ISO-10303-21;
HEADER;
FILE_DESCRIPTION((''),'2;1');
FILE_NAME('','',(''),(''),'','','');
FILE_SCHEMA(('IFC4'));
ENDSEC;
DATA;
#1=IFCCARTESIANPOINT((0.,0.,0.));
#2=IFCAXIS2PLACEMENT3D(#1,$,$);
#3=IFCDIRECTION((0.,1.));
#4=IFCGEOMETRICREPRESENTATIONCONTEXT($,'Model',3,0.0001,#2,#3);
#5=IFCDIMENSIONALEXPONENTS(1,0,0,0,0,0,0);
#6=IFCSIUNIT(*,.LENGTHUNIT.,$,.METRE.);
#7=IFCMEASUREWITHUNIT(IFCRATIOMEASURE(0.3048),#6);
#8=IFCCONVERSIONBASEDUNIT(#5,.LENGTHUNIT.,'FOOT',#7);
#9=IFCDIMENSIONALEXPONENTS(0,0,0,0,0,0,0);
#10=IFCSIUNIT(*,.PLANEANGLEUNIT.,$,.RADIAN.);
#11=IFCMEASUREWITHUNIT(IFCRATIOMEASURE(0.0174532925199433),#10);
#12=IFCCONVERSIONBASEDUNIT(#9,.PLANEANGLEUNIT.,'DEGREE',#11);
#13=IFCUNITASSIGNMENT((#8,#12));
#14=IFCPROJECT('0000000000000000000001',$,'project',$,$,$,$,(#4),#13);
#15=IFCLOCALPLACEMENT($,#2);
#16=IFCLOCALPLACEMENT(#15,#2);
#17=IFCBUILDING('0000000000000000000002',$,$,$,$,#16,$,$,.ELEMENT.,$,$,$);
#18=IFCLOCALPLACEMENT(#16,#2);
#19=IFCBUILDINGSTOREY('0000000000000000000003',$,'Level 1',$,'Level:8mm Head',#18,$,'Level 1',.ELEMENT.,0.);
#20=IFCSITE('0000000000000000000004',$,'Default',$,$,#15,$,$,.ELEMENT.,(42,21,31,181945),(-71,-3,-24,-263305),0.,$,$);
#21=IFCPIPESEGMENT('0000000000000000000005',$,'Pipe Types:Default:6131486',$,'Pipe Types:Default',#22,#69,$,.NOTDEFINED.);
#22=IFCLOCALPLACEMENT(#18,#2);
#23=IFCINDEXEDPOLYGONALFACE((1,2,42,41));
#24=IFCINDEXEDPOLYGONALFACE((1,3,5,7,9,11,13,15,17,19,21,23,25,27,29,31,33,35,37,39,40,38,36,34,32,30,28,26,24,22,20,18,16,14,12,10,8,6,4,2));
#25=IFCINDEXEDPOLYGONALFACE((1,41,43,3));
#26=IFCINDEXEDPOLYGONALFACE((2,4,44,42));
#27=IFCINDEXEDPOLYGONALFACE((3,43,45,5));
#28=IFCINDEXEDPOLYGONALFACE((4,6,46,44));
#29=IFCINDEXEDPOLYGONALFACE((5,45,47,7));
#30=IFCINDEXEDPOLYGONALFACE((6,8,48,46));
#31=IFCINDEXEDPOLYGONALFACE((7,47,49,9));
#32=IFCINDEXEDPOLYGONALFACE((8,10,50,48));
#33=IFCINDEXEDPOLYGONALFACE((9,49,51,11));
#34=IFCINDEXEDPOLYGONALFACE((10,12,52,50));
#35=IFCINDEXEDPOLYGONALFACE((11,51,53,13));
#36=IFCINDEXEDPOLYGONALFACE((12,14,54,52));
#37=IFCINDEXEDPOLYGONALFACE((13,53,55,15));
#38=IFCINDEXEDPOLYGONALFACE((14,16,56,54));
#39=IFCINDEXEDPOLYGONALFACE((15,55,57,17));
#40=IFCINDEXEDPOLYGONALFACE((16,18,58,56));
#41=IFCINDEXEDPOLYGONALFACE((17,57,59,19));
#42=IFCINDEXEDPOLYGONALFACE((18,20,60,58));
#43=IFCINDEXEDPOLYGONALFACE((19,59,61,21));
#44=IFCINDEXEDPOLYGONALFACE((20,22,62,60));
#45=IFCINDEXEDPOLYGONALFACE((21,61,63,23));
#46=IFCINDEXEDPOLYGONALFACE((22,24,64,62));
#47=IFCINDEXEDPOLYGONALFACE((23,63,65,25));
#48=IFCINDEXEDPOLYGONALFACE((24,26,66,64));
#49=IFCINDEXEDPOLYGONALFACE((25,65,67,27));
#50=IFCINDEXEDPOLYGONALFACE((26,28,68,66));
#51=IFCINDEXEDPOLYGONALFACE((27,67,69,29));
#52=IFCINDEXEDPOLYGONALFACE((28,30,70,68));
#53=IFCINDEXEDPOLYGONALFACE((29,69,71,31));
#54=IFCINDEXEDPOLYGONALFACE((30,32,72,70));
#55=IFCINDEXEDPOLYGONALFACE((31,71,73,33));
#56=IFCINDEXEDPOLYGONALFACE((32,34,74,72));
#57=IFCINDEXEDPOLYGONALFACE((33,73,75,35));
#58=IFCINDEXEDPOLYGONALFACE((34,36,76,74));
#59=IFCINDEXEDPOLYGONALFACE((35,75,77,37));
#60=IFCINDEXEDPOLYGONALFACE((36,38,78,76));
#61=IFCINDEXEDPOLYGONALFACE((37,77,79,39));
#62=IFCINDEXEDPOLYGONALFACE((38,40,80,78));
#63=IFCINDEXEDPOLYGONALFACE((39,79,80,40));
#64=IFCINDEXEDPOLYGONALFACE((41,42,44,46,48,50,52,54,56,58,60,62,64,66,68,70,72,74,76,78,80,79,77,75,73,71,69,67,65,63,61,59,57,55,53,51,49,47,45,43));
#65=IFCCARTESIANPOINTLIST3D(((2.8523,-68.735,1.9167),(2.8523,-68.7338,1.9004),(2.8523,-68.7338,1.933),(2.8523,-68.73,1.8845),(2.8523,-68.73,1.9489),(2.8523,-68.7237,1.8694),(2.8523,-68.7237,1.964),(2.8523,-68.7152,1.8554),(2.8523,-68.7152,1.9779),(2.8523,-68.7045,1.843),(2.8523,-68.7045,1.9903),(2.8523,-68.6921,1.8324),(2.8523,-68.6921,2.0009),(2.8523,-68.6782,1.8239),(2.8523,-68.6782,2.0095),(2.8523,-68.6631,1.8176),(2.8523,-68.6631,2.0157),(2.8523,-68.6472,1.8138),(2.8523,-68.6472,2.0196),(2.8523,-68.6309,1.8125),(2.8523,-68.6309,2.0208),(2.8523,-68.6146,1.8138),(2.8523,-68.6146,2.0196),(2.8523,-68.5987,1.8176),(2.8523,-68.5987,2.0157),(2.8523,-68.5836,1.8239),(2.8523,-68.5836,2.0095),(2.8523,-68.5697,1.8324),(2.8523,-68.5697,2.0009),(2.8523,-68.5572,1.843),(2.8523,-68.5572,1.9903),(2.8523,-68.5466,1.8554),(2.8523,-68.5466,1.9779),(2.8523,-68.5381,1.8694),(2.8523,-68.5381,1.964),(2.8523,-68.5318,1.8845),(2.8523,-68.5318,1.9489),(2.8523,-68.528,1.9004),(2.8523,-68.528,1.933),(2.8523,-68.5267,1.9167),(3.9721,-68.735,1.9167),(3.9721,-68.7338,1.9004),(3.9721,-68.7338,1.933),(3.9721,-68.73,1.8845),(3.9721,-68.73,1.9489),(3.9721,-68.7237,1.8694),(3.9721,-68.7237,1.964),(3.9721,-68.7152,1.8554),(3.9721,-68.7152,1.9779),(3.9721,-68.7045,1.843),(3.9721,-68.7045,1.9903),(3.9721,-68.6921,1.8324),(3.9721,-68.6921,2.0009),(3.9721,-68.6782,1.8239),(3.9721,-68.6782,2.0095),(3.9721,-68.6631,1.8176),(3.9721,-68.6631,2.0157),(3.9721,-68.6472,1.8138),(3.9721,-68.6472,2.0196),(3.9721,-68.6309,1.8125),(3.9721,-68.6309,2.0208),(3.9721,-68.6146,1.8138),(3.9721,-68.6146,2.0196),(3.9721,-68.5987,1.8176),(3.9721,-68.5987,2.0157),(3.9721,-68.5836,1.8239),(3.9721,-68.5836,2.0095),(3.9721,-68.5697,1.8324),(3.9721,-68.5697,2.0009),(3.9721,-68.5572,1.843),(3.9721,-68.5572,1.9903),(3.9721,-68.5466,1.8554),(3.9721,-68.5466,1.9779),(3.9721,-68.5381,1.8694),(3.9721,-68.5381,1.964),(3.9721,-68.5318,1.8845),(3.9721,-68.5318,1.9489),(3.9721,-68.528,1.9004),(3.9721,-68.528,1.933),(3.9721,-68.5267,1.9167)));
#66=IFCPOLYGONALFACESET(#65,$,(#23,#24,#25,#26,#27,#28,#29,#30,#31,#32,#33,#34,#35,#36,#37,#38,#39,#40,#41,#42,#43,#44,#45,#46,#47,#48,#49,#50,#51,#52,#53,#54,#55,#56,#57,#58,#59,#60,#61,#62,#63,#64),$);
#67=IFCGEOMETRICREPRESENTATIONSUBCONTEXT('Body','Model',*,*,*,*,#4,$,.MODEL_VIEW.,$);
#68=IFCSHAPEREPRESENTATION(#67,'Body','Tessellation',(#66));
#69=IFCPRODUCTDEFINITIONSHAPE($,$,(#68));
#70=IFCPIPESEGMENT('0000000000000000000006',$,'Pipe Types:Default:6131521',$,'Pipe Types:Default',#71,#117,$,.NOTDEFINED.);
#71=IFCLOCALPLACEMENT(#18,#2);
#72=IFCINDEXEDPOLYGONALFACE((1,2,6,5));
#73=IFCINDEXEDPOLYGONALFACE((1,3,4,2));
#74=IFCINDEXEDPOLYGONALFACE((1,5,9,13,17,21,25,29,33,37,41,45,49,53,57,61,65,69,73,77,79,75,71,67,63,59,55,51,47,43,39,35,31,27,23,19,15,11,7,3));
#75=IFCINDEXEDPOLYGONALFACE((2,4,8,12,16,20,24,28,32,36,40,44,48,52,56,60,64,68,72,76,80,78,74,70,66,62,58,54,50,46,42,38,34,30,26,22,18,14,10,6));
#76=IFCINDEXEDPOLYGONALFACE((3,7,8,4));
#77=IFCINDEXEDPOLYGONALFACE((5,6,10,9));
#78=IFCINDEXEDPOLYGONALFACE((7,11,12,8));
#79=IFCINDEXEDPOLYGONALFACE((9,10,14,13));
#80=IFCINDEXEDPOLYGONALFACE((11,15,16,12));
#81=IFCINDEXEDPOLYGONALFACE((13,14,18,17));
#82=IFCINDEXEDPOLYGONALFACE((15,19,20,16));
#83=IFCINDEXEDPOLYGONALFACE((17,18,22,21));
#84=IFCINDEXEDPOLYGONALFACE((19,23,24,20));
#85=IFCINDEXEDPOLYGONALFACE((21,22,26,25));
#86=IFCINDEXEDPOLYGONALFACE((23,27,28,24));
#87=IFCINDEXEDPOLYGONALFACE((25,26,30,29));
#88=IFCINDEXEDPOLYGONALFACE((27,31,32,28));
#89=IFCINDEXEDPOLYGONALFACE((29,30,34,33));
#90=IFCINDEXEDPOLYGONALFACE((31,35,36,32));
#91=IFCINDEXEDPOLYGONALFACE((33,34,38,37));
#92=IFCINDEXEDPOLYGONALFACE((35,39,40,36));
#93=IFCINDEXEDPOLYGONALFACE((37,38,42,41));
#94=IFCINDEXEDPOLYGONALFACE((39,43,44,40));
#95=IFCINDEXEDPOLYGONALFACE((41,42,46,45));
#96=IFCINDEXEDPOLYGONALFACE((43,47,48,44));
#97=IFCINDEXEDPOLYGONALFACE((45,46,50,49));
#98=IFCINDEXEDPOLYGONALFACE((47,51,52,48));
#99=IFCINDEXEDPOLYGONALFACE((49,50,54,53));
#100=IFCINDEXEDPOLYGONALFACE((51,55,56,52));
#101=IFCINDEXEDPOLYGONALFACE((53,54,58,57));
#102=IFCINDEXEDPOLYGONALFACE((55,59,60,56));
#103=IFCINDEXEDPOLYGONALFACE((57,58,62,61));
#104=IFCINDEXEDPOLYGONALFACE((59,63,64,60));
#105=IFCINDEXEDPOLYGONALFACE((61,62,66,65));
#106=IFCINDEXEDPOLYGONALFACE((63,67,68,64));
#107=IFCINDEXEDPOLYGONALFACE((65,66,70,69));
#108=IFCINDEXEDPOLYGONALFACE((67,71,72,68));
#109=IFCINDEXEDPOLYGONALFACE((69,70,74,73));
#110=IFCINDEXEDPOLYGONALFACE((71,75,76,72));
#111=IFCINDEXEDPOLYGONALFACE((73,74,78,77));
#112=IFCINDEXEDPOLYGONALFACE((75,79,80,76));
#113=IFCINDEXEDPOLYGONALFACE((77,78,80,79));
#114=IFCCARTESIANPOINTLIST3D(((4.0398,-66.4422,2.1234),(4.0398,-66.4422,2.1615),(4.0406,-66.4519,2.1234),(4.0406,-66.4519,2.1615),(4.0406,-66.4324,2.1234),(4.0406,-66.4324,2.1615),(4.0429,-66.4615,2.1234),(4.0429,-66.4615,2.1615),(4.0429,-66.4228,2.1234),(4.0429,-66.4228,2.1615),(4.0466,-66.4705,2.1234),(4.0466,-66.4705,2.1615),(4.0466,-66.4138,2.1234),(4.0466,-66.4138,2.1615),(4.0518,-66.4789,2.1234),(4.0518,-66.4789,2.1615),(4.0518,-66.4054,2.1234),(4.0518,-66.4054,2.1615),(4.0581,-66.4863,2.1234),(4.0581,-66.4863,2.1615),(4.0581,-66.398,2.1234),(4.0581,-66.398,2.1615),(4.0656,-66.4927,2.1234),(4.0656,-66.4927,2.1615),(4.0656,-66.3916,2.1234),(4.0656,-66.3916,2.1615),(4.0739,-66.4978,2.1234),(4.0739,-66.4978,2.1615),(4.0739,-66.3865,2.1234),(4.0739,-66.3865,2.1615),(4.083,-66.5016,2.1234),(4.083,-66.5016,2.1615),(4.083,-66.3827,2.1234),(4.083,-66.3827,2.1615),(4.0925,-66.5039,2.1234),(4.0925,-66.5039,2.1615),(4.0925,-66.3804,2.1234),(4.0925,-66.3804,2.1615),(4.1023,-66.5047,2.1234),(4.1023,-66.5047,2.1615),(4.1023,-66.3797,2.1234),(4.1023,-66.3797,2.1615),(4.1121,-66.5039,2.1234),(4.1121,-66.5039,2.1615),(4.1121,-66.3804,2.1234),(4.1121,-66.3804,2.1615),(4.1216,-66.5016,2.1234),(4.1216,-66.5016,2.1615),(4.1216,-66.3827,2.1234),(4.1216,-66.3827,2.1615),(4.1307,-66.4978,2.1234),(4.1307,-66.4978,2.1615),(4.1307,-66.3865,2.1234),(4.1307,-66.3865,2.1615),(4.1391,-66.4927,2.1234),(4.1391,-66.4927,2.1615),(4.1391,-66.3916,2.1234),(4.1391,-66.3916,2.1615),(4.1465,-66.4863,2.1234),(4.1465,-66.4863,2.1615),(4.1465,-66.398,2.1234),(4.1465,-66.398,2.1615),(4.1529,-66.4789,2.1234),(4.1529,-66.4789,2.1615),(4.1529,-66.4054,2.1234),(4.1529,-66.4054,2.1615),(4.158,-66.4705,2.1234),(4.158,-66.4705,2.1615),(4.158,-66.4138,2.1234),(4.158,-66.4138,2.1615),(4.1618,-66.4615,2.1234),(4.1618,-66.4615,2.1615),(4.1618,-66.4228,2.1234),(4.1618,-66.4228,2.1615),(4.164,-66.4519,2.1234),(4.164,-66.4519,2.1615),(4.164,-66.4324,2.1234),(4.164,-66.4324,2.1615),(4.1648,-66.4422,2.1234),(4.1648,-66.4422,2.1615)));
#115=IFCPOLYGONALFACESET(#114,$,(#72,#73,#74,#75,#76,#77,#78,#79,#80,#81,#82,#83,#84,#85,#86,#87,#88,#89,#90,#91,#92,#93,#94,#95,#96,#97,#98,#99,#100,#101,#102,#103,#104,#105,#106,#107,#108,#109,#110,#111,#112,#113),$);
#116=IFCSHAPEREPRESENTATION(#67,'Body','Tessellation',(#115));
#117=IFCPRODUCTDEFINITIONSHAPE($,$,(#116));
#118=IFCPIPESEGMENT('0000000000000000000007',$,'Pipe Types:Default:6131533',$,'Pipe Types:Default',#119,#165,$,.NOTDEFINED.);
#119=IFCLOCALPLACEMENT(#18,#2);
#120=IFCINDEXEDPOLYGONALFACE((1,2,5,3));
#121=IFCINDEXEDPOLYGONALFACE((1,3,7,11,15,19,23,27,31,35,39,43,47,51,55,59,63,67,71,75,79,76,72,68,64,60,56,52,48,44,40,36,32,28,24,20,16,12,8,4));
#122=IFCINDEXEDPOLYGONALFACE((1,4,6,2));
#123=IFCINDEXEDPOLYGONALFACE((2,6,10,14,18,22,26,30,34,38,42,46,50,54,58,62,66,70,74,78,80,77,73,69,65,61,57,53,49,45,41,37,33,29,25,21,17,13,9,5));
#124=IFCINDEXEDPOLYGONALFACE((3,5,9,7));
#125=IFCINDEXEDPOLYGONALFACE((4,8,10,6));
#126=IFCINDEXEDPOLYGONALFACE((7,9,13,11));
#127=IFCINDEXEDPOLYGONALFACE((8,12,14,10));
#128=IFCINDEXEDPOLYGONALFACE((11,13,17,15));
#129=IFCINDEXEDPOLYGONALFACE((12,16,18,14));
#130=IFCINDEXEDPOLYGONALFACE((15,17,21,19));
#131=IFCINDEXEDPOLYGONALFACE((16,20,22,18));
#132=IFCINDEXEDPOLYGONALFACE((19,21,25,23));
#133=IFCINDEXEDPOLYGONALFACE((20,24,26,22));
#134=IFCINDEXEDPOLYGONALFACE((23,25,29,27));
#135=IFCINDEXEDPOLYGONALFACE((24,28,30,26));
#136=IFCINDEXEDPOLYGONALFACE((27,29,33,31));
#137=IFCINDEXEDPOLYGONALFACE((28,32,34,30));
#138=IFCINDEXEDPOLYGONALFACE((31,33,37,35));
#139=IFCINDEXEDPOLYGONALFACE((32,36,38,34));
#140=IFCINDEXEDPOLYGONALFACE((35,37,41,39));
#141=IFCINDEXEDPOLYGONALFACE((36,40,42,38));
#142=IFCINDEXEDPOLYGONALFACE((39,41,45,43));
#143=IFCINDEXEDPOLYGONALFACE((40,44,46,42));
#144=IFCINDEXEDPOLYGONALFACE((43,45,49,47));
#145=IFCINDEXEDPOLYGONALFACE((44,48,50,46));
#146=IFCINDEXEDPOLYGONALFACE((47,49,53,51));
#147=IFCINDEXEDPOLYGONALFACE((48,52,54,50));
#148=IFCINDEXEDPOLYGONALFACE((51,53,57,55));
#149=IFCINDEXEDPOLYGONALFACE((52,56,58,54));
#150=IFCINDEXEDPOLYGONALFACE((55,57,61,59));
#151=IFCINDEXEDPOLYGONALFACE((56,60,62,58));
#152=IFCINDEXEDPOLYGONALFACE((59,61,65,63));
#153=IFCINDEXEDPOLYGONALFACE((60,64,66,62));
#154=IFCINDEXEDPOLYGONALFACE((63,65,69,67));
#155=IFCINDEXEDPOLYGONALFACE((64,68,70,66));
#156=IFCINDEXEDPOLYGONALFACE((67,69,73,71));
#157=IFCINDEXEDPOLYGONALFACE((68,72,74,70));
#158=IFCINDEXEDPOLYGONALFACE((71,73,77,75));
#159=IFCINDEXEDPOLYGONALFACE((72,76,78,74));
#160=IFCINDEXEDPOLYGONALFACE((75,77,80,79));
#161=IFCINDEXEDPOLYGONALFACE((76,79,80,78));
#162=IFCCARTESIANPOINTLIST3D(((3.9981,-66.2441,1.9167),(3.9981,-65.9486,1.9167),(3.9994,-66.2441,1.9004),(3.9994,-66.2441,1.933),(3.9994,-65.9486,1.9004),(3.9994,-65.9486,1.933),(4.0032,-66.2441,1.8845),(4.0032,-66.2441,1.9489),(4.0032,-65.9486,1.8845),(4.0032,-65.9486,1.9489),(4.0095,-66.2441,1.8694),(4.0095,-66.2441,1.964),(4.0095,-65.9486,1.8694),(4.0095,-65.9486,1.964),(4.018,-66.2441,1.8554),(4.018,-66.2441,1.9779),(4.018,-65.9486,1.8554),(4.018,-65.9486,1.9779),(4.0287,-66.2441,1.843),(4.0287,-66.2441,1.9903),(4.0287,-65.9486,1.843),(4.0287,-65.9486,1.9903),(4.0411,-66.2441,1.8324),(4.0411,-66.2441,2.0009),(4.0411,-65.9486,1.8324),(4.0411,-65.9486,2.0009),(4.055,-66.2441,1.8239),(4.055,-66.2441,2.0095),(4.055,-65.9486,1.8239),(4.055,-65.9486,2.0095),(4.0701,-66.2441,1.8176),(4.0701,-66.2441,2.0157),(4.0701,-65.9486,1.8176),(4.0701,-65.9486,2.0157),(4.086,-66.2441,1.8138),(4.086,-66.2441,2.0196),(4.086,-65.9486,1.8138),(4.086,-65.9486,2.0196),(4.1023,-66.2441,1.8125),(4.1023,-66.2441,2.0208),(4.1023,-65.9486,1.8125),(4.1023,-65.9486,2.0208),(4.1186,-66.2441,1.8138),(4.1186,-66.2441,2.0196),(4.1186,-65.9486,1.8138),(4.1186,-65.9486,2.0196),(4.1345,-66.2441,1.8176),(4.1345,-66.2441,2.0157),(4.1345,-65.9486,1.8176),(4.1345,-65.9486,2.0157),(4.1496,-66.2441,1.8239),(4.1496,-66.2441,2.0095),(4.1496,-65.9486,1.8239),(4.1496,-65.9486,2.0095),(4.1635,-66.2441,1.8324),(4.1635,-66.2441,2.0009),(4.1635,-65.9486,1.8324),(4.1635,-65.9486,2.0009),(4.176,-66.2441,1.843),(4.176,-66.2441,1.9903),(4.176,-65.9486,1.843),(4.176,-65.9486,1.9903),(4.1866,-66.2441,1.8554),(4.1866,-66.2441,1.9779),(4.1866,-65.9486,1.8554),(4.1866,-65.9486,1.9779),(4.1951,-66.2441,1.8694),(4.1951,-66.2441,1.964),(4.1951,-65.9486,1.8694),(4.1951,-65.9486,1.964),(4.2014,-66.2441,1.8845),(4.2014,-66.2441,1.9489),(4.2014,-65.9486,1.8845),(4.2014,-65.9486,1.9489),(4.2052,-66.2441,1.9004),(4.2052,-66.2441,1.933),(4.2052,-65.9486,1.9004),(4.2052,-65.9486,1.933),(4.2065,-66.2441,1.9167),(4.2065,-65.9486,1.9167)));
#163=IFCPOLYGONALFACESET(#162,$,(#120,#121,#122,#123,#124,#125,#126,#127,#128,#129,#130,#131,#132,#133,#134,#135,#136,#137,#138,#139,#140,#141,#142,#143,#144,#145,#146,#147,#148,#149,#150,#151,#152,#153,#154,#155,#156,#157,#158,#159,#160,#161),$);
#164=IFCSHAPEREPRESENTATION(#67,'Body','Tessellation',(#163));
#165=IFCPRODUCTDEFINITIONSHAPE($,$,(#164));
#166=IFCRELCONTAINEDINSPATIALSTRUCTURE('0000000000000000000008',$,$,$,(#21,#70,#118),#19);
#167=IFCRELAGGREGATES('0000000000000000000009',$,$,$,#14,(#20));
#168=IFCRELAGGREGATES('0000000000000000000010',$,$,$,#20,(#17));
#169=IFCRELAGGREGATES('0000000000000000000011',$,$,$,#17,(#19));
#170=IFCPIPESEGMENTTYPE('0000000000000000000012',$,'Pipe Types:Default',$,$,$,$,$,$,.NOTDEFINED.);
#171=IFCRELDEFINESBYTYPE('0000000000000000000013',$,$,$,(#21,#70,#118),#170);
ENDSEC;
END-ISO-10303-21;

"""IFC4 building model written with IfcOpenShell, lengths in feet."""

from ifc_helpers import new_model, entity, si_unit, converted_unit, direction, frame, origin, place, context, subcontext, project, spatial, indexed_curve, outline, extrude, type_object, element, save


model = new_model("IFC4")

# Units and contexts
model_context = context("Model", 3, precision=0.0001, world=origin(), true_north=direction((0.0, 1.0)))
body_context = subcontext(model_context, "Body", "Model", "MODEL_VIEW")
ifc_project = project(units=[converted_unit("LENGTHUNIT", "FOOT", entity("IfcRatioMeasure", 0.3048), si_unit("LENGTHUNIT", "METRE"), dimensions=[1, 0, 0, 0, 0, 0, 0]), converted_unit("PLANEANGLEUNIT", "DEGREE", entity("IfcRatioMeasure", 0.0174532925199433), si_unit("PLANEANGLEUNIT", "RADIAN"), dimensions=[0, 0, 0, 0, 0, 0, 0])], contexts=[model_context])

# Site, building, storey
site_placement = place(None, origin())
site = spatial("IfcSite", under=ifc_project, at=site_placement, Name="Default", CompositionType="ELEMENT", RefLatitude=(42, 21, 31, 181945), RefLongitude=(-71, -3, -24, -263305), RefElevation=0.0)
building_placement = place(site_placement, origin())
building = spatial("IfcBuilding", under=site, at=building_placement, CompositionType="ELEMENT")
storey_placement = place(building_placement, origin())
storey = spatial("IfcBuildingStorey", under=building, at=storey_placement, Name="Level 1", ObjectType="Level:8mm Head", LongName="Level 1", CompositionType="ELEMENT", Elevation=0.0)

# Pipe segments
pipe_segment_type = type_object("IfcPipeSegmentType", Name="Pipe Types:Default", PredefinedType="NOTDEFINED")
pipe_segment_1_placement = place(storey_placement, origin())
element("IfcPipeSegment", 1, at=pipe_segment_1_placement, inside=storey, type_object=pipe_segment_type, Name="Pipe Types:Default:6131486", ObjectType="Pipe Types:Default", PredefinedType="NOTDEFINED", context=body_context, shape_type="SweptSolid", body=[
    extrude(outline(indexed_curve([(0.1042, 0.0), (0.1029, 0.0163), (0.0991, 0.0322), (0.0928, 0.0473), (0.0843, 0.0612), (0.0737, 0.0737), (0.0612, 0.0843), (0.0473, 0.0928), (0.0322, 0.0991), (0.0163, 0.1029), (0.0, 0.1042), (-0.0163, 0.1029), (-0.0322, 0.0991), (-0.0473, 0.0928), (-0.0612, 0.0843), (-0.0737, 0.0737), (-0.0843, 0.0612), (-0.0928, 0.0473), (-0.0991, 0.0322), (-0.1029, 0.0163), (-0.1042, 0.0), (-0.1029, -0.0163), (-0.0991, -0.0322), (-0.0928, -0.0473), (-0.0843, -0.0612), (-0.0737, -0.0737), (-0.0612, -0.0843), (-0.0473, -0.0928), (-0.0322, -0.0991), (-0.0163, -0.1029), (0.0, -0.1042), (0.0163, -0.1029), (0.0322, -0.0991), (0.0473, -0.0928), (0.0612, -0.0843), (0.0737, -0.0737), (0.0843, -0.0612), (0.0928, -0.0473), (0.0991, -0.0322), (0.1029, -0.0163), (0.1042, 0.0)], self_intersect=False)), frame((2.8523, -68.6309, 1.9167), z_axis=(1.0, 0.0, 0.0), x_axis=(0.0, 1.0, 0.0)), (0.0, 0.0, 1.0), 1.1198),
])
pipe_segment_2_placement = place(storey_placement, origin())
element("IfcPipeSegment", 2, at=pipe_segment_2_placement, inside=storey, type_object=pipe_segment_type, Name="Pipe Types:Default:6131521", ObjectType="Pipe Types:Default", PredefinedType="NOTDEFINED", context=body_context, shape_type="SweptSolid", body=[
    extrude(outline(indexed_curve([(0.0625, 0.0), (0.0617, 0.0098), (0.0594, 0.0193), (0.0557, 0.0284), (0.0506, 0.0367), (0.0442, 0.0442), (0.0367, 0.0506), (0.0284, 0.0557), (0.0193, 0.0594), (0.0098, 0.0617), (0.0, 0.0625), (-0.0098, 0.0617), (-0.0193, 0.0594), (-0.0284, 0.0557), (-0.0367, 0.0506), (-0.0442, 0.0442), (-0.0506, 0.0367), (-0.0557, 0.0284), (-0.0594, 0.0193), (-0.0617, 0.0098), (-0.0625, 0.0), (-0.0617, -0.0098), (-0.0594, -0.0193), (-0.0557, -0.0284), (-0.0506, -0.0367), (-0.0442, -0.0442), (-0.0367, -0.0506), (-0.0284, -0.0557), (-0.0193, -0.0594), (-0.0098, -0.0617), (0.0, -0.0625), (0.0098, -0.0617), (0.0193, -0.0594), (0.0284, -0.0557), (0.0367, -0.0506), (0.0442, -0.0442), (0.0506, -0.0367), (0.0557, -0.0284), (0.0594, -0.0193), (0.0617, -0.0098), (0.0625, 0.0)], self_intersect=False)), frame((4.1023, -66.4422, 2.1234), z_axis=(0.0, 0.0, 1.0), x_axis=(-1.0, 0.0, 0.0)), (0.0, 0.0, 1.0), 0.0381),
])
pipe_segment_3_placement = place(storey_placement, origin())
element("IfcPipeSegment", 3, at=pipe_segment_3_placement, inside=storey, type_object=pipe_segment_type, Name="Pipe Types:Default:6131533", ObjectType="Pipe Types:Default", PredefinedType="NOTDEFINED", context=body_context, shape_type="SweptSolid", body=[
    extrude(outline(indexed_curve([(0.1042, 0.0), (0.1029, 0.0163), (0.0991, 0.0322), (0.0928, 0.0473), (0.0843, 0.0612), (0.0737, 0.0737), (0.0612, 0.0843), (0.0473, 0.0928), (0.0322, 0.0991), (0.0163, 0.1029), (0.0, 0.1042), (-0.0163, 0.1029), (-0.0322, 0.0991), (-0.0473, 0.0928), (-0.0612, 0.0843), (-0.0737, 0.0737), (-0.0843, 0.0612), (-0.0928, 0.0473), (-0.0991, 0.0322), (-0.1029, 0.0163), (-0.1042, 0.0), (-0.1029, -0.0163), (-0.0991, -0.0322), (-0.0928, -0.0473), (-0.0843, -0.0612), (-0.0737, -0.0737), (-0.0612, -0.0843), (-0.0473, -0.0928), (-0.0322, -0.0991), (-0.0163, -0.1029), (0.0, -0.1042), (0.0163, -0.1029), (0.0322, -0.0991), (0.0473, -0.0928), (0.0612, -0.0843), (0.0737, -0.0737), (0.0843, -0.0612), (0.0928, -0.0473), (0.0991, -0.0322), (0.1029, -0.0163), (0.1042, 0.0)], self_intersect=False)), frame((4.1023, -66.2441, 1.9167), z_axis=(0.0, 1.0, 0.0), x_axis=(-1.0, 0.0, 0.0)), (0.0, 0.0, 1.0), 0.2955),
])

save(model, "model.ifc")
